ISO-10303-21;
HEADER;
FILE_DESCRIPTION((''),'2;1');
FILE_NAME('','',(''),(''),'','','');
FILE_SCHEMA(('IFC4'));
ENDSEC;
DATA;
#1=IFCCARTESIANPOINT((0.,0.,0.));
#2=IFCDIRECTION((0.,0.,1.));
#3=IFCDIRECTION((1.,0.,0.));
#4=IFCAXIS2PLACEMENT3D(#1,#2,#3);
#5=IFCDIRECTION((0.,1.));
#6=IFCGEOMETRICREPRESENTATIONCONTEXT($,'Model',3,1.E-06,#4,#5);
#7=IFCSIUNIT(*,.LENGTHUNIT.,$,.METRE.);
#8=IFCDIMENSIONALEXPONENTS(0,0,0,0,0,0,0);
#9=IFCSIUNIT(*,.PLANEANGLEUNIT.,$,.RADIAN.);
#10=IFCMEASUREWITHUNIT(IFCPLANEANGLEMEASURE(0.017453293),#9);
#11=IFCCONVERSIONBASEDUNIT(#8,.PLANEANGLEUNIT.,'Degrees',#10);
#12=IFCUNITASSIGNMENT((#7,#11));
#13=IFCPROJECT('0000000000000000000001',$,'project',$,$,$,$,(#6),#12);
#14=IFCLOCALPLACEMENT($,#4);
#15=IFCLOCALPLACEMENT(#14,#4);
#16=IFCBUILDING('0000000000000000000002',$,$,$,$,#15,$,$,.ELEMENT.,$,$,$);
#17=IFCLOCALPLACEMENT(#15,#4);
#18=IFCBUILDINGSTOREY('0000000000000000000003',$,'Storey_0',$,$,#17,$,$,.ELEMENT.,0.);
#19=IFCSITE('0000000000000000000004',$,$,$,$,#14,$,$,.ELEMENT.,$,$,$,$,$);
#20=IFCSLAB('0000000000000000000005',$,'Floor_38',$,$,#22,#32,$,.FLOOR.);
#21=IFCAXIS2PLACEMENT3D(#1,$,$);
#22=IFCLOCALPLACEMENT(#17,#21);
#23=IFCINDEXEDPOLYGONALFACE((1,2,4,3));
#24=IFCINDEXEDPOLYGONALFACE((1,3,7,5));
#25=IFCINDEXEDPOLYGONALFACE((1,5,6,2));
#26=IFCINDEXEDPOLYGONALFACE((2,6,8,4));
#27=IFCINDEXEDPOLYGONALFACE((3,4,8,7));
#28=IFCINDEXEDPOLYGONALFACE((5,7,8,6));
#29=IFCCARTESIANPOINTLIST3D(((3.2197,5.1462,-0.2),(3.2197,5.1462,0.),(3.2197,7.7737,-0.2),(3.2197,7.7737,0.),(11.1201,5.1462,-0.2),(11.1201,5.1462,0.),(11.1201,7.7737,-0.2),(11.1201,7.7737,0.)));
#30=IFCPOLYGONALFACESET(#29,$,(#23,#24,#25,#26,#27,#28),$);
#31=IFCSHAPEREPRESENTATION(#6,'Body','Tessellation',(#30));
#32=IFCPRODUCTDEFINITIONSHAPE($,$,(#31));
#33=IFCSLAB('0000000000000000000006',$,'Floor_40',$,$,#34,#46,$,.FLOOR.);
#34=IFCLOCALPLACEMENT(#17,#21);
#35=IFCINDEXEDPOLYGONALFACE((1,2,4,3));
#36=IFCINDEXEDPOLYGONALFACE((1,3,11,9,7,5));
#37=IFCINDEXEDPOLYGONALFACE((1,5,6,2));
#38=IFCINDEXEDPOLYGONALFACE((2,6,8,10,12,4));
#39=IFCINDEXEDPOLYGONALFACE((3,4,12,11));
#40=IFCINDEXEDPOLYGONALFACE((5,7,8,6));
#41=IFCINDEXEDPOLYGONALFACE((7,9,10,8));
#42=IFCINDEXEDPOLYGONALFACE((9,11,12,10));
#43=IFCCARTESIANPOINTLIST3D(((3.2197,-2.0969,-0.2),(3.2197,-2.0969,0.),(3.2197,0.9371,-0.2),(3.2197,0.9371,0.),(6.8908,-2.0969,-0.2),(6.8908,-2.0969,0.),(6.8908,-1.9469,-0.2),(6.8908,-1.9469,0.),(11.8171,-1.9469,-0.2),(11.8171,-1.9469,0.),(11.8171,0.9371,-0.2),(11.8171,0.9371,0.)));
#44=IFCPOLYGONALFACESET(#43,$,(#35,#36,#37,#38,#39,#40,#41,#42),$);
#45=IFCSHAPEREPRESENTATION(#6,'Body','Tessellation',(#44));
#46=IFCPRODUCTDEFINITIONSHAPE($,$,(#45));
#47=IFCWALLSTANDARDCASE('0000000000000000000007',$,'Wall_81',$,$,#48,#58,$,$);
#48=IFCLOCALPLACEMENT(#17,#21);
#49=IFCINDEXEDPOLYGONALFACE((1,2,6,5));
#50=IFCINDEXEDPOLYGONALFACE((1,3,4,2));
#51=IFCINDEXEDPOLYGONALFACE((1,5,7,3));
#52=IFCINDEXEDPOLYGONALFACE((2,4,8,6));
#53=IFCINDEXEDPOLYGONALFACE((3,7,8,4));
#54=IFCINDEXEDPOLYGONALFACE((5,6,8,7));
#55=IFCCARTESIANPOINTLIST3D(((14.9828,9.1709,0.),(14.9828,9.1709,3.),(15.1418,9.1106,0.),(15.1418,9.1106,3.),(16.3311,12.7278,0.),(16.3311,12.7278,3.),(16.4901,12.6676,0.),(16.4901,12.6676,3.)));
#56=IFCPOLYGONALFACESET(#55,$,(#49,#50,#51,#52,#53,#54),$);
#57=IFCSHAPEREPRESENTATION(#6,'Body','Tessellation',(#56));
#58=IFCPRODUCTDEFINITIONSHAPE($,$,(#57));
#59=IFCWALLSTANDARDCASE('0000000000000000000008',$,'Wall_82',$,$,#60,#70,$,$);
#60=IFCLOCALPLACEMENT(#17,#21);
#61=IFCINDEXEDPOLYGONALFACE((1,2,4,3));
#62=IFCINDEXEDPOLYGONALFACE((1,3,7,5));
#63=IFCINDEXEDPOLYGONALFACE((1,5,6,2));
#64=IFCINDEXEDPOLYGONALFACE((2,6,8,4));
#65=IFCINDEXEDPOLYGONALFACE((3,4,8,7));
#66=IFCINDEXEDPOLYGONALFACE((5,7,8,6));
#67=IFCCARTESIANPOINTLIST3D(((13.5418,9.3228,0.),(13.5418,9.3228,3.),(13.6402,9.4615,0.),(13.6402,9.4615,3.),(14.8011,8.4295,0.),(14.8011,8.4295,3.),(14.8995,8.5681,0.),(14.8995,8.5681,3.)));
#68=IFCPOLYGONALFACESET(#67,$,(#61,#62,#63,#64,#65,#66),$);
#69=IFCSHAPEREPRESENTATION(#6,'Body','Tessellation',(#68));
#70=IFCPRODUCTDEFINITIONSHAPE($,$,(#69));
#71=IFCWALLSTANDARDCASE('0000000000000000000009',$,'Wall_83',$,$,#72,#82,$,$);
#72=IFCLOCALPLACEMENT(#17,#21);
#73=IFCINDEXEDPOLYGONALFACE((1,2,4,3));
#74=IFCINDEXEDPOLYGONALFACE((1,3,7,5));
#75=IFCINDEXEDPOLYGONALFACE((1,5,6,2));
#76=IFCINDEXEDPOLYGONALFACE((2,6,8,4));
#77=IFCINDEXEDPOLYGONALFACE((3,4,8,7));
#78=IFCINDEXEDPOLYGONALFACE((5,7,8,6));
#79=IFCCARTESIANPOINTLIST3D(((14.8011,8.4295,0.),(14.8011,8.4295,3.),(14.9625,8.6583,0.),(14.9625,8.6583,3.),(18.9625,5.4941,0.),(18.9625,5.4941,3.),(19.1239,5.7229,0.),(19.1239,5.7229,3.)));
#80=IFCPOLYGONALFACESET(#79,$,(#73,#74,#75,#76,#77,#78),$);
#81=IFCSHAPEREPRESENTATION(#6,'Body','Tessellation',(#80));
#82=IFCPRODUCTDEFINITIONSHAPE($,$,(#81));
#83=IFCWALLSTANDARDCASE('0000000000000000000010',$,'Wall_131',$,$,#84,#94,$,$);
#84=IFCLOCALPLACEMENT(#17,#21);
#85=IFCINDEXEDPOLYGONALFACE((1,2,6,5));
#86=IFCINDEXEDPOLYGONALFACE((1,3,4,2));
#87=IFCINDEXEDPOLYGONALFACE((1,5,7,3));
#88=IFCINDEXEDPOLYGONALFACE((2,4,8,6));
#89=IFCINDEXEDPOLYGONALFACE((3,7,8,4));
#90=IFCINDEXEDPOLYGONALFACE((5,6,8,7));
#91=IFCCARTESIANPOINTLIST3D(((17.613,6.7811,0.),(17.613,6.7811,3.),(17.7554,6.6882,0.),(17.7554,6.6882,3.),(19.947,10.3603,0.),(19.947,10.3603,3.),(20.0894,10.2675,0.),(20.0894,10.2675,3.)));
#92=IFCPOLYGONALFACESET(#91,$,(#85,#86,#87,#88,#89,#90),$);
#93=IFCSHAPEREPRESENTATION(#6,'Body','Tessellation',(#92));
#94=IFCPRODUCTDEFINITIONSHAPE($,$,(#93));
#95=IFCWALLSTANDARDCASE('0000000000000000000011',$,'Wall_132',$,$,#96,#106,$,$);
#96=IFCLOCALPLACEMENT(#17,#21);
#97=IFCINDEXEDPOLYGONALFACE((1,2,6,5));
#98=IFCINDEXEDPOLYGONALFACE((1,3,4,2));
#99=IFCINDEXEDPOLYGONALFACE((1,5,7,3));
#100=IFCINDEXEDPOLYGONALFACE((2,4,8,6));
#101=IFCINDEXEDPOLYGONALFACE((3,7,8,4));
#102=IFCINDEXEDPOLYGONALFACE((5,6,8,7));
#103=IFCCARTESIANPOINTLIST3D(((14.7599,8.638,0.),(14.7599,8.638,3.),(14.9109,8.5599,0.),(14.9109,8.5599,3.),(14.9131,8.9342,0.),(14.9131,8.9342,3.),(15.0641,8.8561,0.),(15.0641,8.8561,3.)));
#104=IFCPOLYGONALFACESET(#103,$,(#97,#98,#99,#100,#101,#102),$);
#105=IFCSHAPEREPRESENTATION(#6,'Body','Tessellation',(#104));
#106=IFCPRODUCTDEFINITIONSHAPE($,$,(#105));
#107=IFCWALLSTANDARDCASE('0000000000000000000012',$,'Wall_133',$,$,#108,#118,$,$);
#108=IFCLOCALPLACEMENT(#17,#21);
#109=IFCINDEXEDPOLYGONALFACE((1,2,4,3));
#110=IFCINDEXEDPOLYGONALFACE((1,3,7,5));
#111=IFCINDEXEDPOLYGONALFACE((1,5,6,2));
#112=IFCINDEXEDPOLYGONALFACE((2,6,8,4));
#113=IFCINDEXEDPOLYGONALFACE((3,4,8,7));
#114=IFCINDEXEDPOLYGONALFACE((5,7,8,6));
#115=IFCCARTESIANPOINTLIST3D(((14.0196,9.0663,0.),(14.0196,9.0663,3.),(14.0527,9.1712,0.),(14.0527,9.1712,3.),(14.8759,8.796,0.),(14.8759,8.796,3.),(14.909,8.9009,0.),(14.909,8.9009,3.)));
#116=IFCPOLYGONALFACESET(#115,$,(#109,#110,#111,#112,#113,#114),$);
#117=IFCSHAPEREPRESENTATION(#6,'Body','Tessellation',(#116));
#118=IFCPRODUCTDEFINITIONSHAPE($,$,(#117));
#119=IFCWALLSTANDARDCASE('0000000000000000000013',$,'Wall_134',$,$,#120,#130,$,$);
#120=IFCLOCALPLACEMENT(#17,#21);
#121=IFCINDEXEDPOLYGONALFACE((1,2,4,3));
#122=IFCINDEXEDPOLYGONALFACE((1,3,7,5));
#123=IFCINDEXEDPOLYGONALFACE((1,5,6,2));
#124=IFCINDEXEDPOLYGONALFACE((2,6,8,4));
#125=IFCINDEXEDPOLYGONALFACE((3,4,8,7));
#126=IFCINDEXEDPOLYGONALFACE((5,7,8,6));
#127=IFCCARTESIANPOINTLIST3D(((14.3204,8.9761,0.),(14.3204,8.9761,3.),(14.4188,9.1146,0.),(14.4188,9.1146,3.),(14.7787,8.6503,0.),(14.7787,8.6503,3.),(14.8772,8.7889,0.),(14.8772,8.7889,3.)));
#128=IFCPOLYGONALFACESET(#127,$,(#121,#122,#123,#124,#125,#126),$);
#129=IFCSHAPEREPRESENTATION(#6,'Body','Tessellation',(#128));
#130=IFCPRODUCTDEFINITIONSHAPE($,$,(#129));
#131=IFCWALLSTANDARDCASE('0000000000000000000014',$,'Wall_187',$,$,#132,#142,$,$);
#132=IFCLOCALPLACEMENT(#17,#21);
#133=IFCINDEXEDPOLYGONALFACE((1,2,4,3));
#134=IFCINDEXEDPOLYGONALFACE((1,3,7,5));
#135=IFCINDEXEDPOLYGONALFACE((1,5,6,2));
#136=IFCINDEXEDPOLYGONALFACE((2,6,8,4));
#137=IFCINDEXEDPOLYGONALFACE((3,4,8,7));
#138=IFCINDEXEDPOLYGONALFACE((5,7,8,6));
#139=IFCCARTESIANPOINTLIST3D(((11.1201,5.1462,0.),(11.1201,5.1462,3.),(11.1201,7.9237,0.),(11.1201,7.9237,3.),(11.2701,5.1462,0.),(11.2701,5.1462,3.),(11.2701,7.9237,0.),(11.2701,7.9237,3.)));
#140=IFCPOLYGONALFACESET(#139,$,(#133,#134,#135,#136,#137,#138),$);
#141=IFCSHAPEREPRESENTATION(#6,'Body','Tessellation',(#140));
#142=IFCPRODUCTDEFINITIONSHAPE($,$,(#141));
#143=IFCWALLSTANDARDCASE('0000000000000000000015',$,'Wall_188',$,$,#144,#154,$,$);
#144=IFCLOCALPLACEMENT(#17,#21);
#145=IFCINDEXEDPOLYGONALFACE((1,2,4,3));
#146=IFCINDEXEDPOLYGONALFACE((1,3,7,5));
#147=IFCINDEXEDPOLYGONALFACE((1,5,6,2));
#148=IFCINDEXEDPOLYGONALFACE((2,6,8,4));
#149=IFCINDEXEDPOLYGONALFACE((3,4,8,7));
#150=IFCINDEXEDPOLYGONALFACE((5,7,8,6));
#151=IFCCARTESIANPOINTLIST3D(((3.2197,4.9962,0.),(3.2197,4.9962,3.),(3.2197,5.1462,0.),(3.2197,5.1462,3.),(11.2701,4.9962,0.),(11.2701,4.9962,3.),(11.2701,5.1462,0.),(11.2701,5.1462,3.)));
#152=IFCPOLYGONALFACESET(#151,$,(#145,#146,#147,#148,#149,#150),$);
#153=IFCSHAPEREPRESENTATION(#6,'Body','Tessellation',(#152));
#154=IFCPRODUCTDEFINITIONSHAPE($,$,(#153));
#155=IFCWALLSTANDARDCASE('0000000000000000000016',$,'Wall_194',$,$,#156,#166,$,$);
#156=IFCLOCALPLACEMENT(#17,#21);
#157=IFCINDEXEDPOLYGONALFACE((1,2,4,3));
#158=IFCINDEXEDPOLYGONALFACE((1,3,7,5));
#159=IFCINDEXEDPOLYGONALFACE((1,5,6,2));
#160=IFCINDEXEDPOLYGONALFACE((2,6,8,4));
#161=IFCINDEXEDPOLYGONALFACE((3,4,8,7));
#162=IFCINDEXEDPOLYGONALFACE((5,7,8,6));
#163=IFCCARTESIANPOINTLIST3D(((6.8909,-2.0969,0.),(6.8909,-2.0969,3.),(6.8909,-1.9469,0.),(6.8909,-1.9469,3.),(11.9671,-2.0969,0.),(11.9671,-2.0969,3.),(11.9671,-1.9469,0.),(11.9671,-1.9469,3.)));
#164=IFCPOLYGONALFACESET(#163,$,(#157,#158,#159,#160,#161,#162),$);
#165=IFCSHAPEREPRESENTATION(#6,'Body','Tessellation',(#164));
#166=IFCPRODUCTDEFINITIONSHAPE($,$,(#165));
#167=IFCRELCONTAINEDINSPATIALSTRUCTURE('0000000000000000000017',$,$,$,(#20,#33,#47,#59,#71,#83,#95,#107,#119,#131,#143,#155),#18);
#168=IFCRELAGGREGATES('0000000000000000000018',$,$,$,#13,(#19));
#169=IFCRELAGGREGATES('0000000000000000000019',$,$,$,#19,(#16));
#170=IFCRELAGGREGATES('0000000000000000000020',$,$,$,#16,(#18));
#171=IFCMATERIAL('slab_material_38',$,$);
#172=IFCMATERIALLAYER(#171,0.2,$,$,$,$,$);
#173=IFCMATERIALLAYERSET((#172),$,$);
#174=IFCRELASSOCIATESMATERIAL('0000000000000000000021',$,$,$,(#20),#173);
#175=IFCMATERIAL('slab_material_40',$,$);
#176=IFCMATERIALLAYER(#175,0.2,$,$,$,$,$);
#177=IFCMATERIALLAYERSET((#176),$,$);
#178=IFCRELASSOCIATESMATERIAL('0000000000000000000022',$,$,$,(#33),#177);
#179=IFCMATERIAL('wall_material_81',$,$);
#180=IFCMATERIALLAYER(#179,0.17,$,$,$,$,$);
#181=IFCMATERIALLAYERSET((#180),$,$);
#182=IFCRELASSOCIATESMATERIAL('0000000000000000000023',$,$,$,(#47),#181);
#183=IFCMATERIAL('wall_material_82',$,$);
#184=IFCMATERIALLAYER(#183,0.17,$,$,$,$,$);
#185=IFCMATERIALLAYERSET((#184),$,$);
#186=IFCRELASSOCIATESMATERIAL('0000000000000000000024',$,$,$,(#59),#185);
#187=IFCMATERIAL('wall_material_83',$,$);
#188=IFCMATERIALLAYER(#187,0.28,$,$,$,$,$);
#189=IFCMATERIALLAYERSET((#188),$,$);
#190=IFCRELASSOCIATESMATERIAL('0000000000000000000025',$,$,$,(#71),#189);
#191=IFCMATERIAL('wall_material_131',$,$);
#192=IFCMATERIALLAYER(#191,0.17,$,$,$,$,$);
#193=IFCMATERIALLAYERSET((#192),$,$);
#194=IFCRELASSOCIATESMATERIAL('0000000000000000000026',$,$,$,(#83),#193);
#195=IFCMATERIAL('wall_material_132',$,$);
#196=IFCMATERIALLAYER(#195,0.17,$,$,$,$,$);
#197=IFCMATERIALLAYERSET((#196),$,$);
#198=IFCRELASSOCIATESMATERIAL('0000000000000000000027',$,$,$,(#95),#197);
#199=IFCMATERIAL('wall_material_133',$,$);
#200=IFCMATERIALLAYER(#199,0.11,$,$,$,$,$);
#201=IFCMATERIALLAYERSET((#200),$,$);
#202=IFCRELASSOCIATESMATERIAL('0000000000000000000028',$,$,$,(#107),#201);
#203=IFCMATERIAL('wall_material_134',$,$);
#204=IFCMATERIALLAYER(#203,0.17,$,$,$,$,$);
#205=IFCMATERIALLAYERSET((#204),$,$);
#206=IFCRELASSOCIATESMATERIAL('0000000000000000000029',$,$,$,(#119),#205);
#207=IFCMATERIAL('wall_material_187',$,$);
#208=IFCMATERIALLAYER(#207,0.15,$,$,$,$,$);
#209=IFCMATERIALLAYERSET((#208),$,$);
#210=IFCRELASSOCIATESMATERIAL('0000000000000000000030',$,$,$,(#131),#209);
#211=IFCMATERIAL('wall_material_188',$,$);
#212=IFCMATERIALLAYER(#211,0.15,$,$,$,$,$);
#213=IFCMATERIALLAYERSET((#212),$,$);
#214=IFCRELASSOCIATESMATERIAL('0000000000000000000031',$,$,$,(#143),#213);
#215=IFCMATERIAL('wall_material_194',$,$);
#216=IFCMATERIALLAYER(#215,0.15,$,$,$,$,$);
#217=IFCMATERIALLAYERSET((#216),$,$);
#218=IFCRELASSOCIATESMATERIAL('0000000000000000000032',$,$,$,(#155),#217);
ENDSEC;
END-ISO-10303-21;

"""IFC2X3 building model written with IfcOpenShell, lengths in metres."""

from ifc_helpers import new_model, entity, si_unit, converted_unit, direction, frame, origin_with_axes, place, context, project, spatial, polyline, outline, extrude, material, layer, layer_set, layer_usage, element, save


model = new_model("IFC2X3")

# Units and contexts
model_context = context("Model", 3, precision=1e-06, world=origin_with_axes(), true_north=direction((0.0, 1.0)))
ifc_project = project(units=[si_unit("LENGTHUNIT", "METRE"), converted_unit("PLANEANGLEUNIT", "Degrees", entity("IfcPlaneAngleMeasure", 0.017453293), si_unit("PLANEANGLEUNIT", "RADIAN"), dimensions=[0, 0, 0, 0, 0, 0, 0])], contexts=[model_context])

# Site, building, storey
site_placement = place(None, origin_with_axes())
site = spatial("IfcSite", under=ifc_project, at=site_placement, CompositionType="ELEMENT")
building_placement = place(site_placement, origin_with_axes())
building = spatial("IfcBuilding", under=site, at=building_placement, CompositionType="ELEMENT")
storey_placement = place(building_placement, origin_with_axes())
storey = spatial("IfcBuildingStorey", under=building, at=storey_placement, Name="Storey_0", CompositionType="ELEMENT", Elevation=0.0)

# Slabs
ifc_material_1 = material(Name="slab_material_38")
ifc_layer_1 = layer(ifc_material_1, 0.2)
ifc_layer_set_1 = layer_set([ifc_layer_1])
ifc_layer_usage_1 = layer_usage(ifc_layer_set_1, "AXIS3", "POSITIVE", 0.0)
slab_1_placement = place(storey_placement, frame((7.1699, 6.4599, -0.2), z_axis=(0.0, 0.0, 1.0), x_axis=(1.0, 0.0, 0.0)))
element("IfcSlab", 1, at=slab_1_placement, inside=storey, material=ifc_layer_usage_1, Name="Floor_38", PredefinedType="FLOOR", context=model_context, shape_type="SweptSolid", body=[
    extrude(outline(polyline([(3.9502, -1.3137), (-3.9502, -1.3137), (-3.9502, 1.3137), (3.9502, 1.3137), (3.9502, -1.3137)])), origin_with_axes(), (0.0, 0.0, 1.0), 0.2),
])
ifc_material_2 = material(Name="slab_material_40")
ifc_layer_2 = layer(ifc_material_2, 0.2)
ifc_layer_set_2 = layer_set([ifc_layer_2])
ifc_layer_usage_2 = layer_usage(ifc_layer_set_2, "AXIS3", "POSITIVE", 0.0)
slab_2_placement = place(storey_placement, frame((7.5184, -0.5799, -0.2), z_axis=(0.0, 0.0, 1.0), x_axis=(1.0, 0.0, 0.0)))
element("IfcSlab", 2, at=slab_2_placement, inside=storey, material=ifc_layer_usage_2, Name="Floor_40", PredefinedType="FLOOR", context=model_context, shape_type="SweptSolid", body=[
    extrude(outline(polyline([(4.2987, 1.517), (4.2987, -1.367), (-0.6275, -1.367), (-0.6275, -1.517), (-4.2987, -1.517), (-4.2987, 1.517), (4.2987, 1.517)])), origin_with_axes(), (0.0, 0.0, 1.0), 0.2),
])

# Walls
ifc_material_3 = material(Name="wall_material_81")
ifc_layer_3 = layer(ifc_material_3, 0.17)
ifc_layer_set_3 = layer_set([ifc_layer_3])
ifc_layer_usage_3 = layer_usage(ifc_layer_set_3, "AXIS2", "POSITIVE", 0.0)
wall_1_placement = place(storey_placement, frame((15.1418, 9.1106, 0.0), z_axis=(0.0, 0.0, 1.0), x_axis=(0.354446, 0.935076, 0.0)))
element("IfcWallStandardCase", 3, at=wall_1_placement, inside=storey, material=ifc_layer_usage_3, Name="Wall_81", context=model_context, shape_type="SweptSolid", body=[
    extrude(outline(polyline([(0.0, 0.17), (3.8039, 0.17), (3.8039, 0.0), (0.0, 0.0), (0.0, 0.17)])), origin_with_axes(), (0.0, 0.0, 1.0), 3.0),
])
ifc_material_4 = material(Name="wall_material_82")
ifc_layer_4 = layer(ifc_material_4, 0.17)
ifc_layer_set_4 = layer_set([ifc_layer_4])
ifc_layer_usage_4 = layer_usage(ifc_layer_set_4, "AXIS2", "POSITIVE", 0.0)
wall_2_placement = place(storey_placement, frame((13.5418, 9.3228, 0.0), z_axis=(0.0, 0.0, 1.0), x_axis=(0.815599, -0.578618, 0.0)))
element("IfcWallStandardCase", 4, at=wall_2_placement, inside=storey, material=ifc_layer_usage_4, Name="Wall_82", context=model_context, shape_type="SweptSolid", body=[
    extrude(outline(polyline([(0.0, 0.17), (1.544, 0.17), (1.544, 0.0), (0.0, 0.0), (0.0, 0.17)])), origin_with_axes(), (0.0, 0.0, 1.0), 3.0),
])
ifc_material_5 = material(Name="wall_material_83")
ifc_layer_5 = layer(ifc_material_5, 0.28)
ifc_layer_set_5 = layer_set([ifc_layer_5])
ifc_layer_usage_5 = layer_usage(ifc_layer_set_5, "AXIS2", "POSITIVE", 0.0)
wall_3_placement = place(storey_placement, frame((14.8011, 8.4295, 0.0), z_axis=(0.0, 0.0, 1.0), x_axis=(0.817161, -0.576409, 0.0)))
element("IfcWallStandardCase", 5, at=wall_3_placement, inside=storey, material=ifc_layer_usage_5, Name="Wall_83", context=model_context, shape_type="SweptSolid", body=[
    extrude(outline(polyline([(0.0, 0.28), (5.0925, 0.28), (5.0925, 0.0), (0.0, 0.0), (0.0, 0.28)])), origin_with_axes(), (0.0, 0.0, 1.0), 3.0),
])
ifc_material_6 = material(Name="wall_material_131")
ifc_layer_6 = layer(ifc_material_6, 0.17)
ifc_layer_set_6 = layer_set([ifc_layer_6])
ifc_layer_usage_6 = layer_usage(ifc_layer_set_6, "AXIS2", "NEGATIVE", 0.0)
wall_4_placement = place(storey_placement, frame((17.613, 6.7811, 0.0), z_axis=(0.0, 0.0, 1.0), x_axis=(0.546234, 0.837633, 0.0)))
element("IfcWallStandardCase", 6, at=wall_4_placement, inside=storey, material=ifc_layer_usage_6, Name="Wall_131", context=model_context, shape_type="SweptSolid", body=[
    extrude(outline(polyline([(0.0, 0.0), (4.273, 0.0), (4.273, -0.17), (0.0, -0.17), (0.0, 0.0)])), origin_with_axes(), (0.0, 0.0, 1.0), 3.0),
])
ifc_material_7 = material(Name="wall_material_132")
ifc_layer_7 = layer(ifc_material_7, 0.17)
ifc_layer_set_7 = layer_set([ifc_layer_7])
ifc_layer_usage_7 = layer_usage(ifc_layer_set_7, "AXIS2", "NEGATIVE", 0.0)
wall_5_placement = place(storey_placement, frame((15.0641, 8.8561, 0.0), z_axis=(0.0, 0.0, 1.0), x_axis=(-0.459502, -0.888177, 0.0)))
element("IfcWallStandardCase", 7, at=wall_5_placement, inside=storey, material=ifc_layer_usage_7, Name="Wall_132", context=model_context, shape_type="SweptSolid", body=[
    extrude(outline(polyline([(0.0, 0.0), (0.3335, 0.0), (0.3335, -0.17), (0.0, -0.17), (0.0, 0.0)])), origin_with_axes(), (0.0, 0.0, 1.0), 3.0),
])
ifc_material_8 = material(Name="wall_material_133")
ifc_layer_8 = layer(ifc_material_8, 0.11)
ifc_layer_set_8 = layer_set([ifc_layer_8])
ifc_layer_usage_8 = layer_usage(ifc_layer_set_8, "AXIS2", "NEGATIVE", 0.0)
wall_6_placement = place(storey_placement, frame((14.0527, 9.1712, 0.0), z_axis=(0.0, 0.0, 1.0), x_axis=(0.953602, -0.301069, 0.0)))
element("IfcWallStandardCase", 8, at=wall_6_placement, inside=storey, material=ifc_layer_usage_8, Name="Wall_133", context=model_context, shape_type="SweptSolid", body=[
    extrude(outline(polyline([(0.0, 0.0), (0.898, 0.0), (0.898, -0.11), (0.0, -0.11), (0.0, 0.0)])), origin_with_axes(), (0.0, 0.0, 1.0), 3.0),
])
ifc_material_9 = material(Name="wall_material_134")
ifc_layer_9 = layer(ifc_material_9, 0.17)
ifc_layer_set_9 = layer_set([ifc_layer_9])
ifc_layer_usage_9 = layer_usage(ifc_layer_set_9, "AXIS2", "NEGATIVE", 0.0)
wall_7_placement = place(storey_placement, frame((14.7787, 8.6503, 0.0), z_axis=(0.0, 0.0, 1.0), x_axis=(-0.815137, 0.579268, 0.0)))
element("IfcWallStandardCase", 9, at=wall_7_placement, inside=storey, material=ifc_layer_usage_9, Name="Wall_134", context=model_context, shape_type="SweptSolid", body=[
    extrude(outline(polyline([(0.0, 0.0), (0.5623, 0.0), (0.5623, -0.17), (0.0, -0.17), (0.0, 0.0)])), origin_with_axes(), (0.0, 0.0, 1.0), 3.0),
])
ifc_material_10 = material(Name="wall_material_187")
ifc_layer_10 = layer(ifc_material_10, 0.15)
ifc_layer_set_10 = layer_set([ifc_layer_10])
ifc_layer_usage_10 = layer_usage(ifc_layer_set_10, "AXIS2", "NEGATIVE", 0.0)
wall_8_placement = place(storey_placement, frame((11.2701, 7.9237, 0.0), z_axis=(0.0, 0.0, 1.0), x_axis=(0.0, -1.0, 0.0)))
element("IfcWallStandardCase", 10, at=wall_8_placement, inside=storey, material=ifc_layer_usage_10, Name="Wall_187", context=model_context, shape_type="SweptSolid", body=[
    extrude(outline(polyline([(0.0, 0.0), (2.7775, 0.0), (2.7775, -0.15), (0.0, -0.15), (0.0, 0.0)])), origin_with_axes(), (0.0, 0.0, 1.0), 3.0),
])
ifc_material_11 = material(Name="wall_material_188")
ifc_layer_11 = layer(ifc_material_11, 0.15)
ifc_layer_set_11 = layer_set([ifc_layer_11])
ifc_layer_usage_11 = layer_usage(ifc_layer_set_11, "AXIS2", "NEGATIVE", 0.0)
wall_9_placement = place(storey_placement, frame((11.2701, 4.9962, 0.0), z_axis=(0.0, 0.0, 1.0), x_axis=(-1.0, 0.0, 0.0)))
element("IfcWallStandardCase", 11, at=wall_9_placement, inside=storey, material=ifc_layer_usage_11, Name="Wall_188", context=model_context, shape_type="SweptSolid", body=[
    extrude(outline(polyline([(0.0, 0.0), (8.0504, 0.0), (8.0504, -0.15), (0.0, -0.15), (0.0, 0.0)])), origin_with_axes(), (0.0, 0.0, 1.0), 3.0),
])
ifc_material_12 = material(Name="wall_material_194")
ifc_layer_12 = layer(ifc_material_12, 0.15)
ifc_layer_set_12 = layer_set([ifc_layer_12])
ifc_layer_usage_12 = layer_usage(ifc_layer_set_12, "AXIS2", "NEGATIVE", 0.0)
wall_10_placement = place(storey_placement, frame((6.8909, -1.9469, 0.0), z_axis=(0.0, 0.0, 1.0), x_axis=(1.0, 0.0, 0.0)))
element("IfcWallStandardCase", 12, at=wall_10_placement, inside=storey, material=ifc_layer_usage_12, Name="Wall_194", context=model_context, shape_type="SweptSolid", body=[
    extrude(outline(polyline([(0.0, 0.0), (5.0762, 0.0), (5.0762, -0.15), (0.0, -0.15), (0.0, 0.0)])), origin_with_axes(), (0.0, 0.0, 1.0), 3.0),
])

save(model, "model.ifc")
